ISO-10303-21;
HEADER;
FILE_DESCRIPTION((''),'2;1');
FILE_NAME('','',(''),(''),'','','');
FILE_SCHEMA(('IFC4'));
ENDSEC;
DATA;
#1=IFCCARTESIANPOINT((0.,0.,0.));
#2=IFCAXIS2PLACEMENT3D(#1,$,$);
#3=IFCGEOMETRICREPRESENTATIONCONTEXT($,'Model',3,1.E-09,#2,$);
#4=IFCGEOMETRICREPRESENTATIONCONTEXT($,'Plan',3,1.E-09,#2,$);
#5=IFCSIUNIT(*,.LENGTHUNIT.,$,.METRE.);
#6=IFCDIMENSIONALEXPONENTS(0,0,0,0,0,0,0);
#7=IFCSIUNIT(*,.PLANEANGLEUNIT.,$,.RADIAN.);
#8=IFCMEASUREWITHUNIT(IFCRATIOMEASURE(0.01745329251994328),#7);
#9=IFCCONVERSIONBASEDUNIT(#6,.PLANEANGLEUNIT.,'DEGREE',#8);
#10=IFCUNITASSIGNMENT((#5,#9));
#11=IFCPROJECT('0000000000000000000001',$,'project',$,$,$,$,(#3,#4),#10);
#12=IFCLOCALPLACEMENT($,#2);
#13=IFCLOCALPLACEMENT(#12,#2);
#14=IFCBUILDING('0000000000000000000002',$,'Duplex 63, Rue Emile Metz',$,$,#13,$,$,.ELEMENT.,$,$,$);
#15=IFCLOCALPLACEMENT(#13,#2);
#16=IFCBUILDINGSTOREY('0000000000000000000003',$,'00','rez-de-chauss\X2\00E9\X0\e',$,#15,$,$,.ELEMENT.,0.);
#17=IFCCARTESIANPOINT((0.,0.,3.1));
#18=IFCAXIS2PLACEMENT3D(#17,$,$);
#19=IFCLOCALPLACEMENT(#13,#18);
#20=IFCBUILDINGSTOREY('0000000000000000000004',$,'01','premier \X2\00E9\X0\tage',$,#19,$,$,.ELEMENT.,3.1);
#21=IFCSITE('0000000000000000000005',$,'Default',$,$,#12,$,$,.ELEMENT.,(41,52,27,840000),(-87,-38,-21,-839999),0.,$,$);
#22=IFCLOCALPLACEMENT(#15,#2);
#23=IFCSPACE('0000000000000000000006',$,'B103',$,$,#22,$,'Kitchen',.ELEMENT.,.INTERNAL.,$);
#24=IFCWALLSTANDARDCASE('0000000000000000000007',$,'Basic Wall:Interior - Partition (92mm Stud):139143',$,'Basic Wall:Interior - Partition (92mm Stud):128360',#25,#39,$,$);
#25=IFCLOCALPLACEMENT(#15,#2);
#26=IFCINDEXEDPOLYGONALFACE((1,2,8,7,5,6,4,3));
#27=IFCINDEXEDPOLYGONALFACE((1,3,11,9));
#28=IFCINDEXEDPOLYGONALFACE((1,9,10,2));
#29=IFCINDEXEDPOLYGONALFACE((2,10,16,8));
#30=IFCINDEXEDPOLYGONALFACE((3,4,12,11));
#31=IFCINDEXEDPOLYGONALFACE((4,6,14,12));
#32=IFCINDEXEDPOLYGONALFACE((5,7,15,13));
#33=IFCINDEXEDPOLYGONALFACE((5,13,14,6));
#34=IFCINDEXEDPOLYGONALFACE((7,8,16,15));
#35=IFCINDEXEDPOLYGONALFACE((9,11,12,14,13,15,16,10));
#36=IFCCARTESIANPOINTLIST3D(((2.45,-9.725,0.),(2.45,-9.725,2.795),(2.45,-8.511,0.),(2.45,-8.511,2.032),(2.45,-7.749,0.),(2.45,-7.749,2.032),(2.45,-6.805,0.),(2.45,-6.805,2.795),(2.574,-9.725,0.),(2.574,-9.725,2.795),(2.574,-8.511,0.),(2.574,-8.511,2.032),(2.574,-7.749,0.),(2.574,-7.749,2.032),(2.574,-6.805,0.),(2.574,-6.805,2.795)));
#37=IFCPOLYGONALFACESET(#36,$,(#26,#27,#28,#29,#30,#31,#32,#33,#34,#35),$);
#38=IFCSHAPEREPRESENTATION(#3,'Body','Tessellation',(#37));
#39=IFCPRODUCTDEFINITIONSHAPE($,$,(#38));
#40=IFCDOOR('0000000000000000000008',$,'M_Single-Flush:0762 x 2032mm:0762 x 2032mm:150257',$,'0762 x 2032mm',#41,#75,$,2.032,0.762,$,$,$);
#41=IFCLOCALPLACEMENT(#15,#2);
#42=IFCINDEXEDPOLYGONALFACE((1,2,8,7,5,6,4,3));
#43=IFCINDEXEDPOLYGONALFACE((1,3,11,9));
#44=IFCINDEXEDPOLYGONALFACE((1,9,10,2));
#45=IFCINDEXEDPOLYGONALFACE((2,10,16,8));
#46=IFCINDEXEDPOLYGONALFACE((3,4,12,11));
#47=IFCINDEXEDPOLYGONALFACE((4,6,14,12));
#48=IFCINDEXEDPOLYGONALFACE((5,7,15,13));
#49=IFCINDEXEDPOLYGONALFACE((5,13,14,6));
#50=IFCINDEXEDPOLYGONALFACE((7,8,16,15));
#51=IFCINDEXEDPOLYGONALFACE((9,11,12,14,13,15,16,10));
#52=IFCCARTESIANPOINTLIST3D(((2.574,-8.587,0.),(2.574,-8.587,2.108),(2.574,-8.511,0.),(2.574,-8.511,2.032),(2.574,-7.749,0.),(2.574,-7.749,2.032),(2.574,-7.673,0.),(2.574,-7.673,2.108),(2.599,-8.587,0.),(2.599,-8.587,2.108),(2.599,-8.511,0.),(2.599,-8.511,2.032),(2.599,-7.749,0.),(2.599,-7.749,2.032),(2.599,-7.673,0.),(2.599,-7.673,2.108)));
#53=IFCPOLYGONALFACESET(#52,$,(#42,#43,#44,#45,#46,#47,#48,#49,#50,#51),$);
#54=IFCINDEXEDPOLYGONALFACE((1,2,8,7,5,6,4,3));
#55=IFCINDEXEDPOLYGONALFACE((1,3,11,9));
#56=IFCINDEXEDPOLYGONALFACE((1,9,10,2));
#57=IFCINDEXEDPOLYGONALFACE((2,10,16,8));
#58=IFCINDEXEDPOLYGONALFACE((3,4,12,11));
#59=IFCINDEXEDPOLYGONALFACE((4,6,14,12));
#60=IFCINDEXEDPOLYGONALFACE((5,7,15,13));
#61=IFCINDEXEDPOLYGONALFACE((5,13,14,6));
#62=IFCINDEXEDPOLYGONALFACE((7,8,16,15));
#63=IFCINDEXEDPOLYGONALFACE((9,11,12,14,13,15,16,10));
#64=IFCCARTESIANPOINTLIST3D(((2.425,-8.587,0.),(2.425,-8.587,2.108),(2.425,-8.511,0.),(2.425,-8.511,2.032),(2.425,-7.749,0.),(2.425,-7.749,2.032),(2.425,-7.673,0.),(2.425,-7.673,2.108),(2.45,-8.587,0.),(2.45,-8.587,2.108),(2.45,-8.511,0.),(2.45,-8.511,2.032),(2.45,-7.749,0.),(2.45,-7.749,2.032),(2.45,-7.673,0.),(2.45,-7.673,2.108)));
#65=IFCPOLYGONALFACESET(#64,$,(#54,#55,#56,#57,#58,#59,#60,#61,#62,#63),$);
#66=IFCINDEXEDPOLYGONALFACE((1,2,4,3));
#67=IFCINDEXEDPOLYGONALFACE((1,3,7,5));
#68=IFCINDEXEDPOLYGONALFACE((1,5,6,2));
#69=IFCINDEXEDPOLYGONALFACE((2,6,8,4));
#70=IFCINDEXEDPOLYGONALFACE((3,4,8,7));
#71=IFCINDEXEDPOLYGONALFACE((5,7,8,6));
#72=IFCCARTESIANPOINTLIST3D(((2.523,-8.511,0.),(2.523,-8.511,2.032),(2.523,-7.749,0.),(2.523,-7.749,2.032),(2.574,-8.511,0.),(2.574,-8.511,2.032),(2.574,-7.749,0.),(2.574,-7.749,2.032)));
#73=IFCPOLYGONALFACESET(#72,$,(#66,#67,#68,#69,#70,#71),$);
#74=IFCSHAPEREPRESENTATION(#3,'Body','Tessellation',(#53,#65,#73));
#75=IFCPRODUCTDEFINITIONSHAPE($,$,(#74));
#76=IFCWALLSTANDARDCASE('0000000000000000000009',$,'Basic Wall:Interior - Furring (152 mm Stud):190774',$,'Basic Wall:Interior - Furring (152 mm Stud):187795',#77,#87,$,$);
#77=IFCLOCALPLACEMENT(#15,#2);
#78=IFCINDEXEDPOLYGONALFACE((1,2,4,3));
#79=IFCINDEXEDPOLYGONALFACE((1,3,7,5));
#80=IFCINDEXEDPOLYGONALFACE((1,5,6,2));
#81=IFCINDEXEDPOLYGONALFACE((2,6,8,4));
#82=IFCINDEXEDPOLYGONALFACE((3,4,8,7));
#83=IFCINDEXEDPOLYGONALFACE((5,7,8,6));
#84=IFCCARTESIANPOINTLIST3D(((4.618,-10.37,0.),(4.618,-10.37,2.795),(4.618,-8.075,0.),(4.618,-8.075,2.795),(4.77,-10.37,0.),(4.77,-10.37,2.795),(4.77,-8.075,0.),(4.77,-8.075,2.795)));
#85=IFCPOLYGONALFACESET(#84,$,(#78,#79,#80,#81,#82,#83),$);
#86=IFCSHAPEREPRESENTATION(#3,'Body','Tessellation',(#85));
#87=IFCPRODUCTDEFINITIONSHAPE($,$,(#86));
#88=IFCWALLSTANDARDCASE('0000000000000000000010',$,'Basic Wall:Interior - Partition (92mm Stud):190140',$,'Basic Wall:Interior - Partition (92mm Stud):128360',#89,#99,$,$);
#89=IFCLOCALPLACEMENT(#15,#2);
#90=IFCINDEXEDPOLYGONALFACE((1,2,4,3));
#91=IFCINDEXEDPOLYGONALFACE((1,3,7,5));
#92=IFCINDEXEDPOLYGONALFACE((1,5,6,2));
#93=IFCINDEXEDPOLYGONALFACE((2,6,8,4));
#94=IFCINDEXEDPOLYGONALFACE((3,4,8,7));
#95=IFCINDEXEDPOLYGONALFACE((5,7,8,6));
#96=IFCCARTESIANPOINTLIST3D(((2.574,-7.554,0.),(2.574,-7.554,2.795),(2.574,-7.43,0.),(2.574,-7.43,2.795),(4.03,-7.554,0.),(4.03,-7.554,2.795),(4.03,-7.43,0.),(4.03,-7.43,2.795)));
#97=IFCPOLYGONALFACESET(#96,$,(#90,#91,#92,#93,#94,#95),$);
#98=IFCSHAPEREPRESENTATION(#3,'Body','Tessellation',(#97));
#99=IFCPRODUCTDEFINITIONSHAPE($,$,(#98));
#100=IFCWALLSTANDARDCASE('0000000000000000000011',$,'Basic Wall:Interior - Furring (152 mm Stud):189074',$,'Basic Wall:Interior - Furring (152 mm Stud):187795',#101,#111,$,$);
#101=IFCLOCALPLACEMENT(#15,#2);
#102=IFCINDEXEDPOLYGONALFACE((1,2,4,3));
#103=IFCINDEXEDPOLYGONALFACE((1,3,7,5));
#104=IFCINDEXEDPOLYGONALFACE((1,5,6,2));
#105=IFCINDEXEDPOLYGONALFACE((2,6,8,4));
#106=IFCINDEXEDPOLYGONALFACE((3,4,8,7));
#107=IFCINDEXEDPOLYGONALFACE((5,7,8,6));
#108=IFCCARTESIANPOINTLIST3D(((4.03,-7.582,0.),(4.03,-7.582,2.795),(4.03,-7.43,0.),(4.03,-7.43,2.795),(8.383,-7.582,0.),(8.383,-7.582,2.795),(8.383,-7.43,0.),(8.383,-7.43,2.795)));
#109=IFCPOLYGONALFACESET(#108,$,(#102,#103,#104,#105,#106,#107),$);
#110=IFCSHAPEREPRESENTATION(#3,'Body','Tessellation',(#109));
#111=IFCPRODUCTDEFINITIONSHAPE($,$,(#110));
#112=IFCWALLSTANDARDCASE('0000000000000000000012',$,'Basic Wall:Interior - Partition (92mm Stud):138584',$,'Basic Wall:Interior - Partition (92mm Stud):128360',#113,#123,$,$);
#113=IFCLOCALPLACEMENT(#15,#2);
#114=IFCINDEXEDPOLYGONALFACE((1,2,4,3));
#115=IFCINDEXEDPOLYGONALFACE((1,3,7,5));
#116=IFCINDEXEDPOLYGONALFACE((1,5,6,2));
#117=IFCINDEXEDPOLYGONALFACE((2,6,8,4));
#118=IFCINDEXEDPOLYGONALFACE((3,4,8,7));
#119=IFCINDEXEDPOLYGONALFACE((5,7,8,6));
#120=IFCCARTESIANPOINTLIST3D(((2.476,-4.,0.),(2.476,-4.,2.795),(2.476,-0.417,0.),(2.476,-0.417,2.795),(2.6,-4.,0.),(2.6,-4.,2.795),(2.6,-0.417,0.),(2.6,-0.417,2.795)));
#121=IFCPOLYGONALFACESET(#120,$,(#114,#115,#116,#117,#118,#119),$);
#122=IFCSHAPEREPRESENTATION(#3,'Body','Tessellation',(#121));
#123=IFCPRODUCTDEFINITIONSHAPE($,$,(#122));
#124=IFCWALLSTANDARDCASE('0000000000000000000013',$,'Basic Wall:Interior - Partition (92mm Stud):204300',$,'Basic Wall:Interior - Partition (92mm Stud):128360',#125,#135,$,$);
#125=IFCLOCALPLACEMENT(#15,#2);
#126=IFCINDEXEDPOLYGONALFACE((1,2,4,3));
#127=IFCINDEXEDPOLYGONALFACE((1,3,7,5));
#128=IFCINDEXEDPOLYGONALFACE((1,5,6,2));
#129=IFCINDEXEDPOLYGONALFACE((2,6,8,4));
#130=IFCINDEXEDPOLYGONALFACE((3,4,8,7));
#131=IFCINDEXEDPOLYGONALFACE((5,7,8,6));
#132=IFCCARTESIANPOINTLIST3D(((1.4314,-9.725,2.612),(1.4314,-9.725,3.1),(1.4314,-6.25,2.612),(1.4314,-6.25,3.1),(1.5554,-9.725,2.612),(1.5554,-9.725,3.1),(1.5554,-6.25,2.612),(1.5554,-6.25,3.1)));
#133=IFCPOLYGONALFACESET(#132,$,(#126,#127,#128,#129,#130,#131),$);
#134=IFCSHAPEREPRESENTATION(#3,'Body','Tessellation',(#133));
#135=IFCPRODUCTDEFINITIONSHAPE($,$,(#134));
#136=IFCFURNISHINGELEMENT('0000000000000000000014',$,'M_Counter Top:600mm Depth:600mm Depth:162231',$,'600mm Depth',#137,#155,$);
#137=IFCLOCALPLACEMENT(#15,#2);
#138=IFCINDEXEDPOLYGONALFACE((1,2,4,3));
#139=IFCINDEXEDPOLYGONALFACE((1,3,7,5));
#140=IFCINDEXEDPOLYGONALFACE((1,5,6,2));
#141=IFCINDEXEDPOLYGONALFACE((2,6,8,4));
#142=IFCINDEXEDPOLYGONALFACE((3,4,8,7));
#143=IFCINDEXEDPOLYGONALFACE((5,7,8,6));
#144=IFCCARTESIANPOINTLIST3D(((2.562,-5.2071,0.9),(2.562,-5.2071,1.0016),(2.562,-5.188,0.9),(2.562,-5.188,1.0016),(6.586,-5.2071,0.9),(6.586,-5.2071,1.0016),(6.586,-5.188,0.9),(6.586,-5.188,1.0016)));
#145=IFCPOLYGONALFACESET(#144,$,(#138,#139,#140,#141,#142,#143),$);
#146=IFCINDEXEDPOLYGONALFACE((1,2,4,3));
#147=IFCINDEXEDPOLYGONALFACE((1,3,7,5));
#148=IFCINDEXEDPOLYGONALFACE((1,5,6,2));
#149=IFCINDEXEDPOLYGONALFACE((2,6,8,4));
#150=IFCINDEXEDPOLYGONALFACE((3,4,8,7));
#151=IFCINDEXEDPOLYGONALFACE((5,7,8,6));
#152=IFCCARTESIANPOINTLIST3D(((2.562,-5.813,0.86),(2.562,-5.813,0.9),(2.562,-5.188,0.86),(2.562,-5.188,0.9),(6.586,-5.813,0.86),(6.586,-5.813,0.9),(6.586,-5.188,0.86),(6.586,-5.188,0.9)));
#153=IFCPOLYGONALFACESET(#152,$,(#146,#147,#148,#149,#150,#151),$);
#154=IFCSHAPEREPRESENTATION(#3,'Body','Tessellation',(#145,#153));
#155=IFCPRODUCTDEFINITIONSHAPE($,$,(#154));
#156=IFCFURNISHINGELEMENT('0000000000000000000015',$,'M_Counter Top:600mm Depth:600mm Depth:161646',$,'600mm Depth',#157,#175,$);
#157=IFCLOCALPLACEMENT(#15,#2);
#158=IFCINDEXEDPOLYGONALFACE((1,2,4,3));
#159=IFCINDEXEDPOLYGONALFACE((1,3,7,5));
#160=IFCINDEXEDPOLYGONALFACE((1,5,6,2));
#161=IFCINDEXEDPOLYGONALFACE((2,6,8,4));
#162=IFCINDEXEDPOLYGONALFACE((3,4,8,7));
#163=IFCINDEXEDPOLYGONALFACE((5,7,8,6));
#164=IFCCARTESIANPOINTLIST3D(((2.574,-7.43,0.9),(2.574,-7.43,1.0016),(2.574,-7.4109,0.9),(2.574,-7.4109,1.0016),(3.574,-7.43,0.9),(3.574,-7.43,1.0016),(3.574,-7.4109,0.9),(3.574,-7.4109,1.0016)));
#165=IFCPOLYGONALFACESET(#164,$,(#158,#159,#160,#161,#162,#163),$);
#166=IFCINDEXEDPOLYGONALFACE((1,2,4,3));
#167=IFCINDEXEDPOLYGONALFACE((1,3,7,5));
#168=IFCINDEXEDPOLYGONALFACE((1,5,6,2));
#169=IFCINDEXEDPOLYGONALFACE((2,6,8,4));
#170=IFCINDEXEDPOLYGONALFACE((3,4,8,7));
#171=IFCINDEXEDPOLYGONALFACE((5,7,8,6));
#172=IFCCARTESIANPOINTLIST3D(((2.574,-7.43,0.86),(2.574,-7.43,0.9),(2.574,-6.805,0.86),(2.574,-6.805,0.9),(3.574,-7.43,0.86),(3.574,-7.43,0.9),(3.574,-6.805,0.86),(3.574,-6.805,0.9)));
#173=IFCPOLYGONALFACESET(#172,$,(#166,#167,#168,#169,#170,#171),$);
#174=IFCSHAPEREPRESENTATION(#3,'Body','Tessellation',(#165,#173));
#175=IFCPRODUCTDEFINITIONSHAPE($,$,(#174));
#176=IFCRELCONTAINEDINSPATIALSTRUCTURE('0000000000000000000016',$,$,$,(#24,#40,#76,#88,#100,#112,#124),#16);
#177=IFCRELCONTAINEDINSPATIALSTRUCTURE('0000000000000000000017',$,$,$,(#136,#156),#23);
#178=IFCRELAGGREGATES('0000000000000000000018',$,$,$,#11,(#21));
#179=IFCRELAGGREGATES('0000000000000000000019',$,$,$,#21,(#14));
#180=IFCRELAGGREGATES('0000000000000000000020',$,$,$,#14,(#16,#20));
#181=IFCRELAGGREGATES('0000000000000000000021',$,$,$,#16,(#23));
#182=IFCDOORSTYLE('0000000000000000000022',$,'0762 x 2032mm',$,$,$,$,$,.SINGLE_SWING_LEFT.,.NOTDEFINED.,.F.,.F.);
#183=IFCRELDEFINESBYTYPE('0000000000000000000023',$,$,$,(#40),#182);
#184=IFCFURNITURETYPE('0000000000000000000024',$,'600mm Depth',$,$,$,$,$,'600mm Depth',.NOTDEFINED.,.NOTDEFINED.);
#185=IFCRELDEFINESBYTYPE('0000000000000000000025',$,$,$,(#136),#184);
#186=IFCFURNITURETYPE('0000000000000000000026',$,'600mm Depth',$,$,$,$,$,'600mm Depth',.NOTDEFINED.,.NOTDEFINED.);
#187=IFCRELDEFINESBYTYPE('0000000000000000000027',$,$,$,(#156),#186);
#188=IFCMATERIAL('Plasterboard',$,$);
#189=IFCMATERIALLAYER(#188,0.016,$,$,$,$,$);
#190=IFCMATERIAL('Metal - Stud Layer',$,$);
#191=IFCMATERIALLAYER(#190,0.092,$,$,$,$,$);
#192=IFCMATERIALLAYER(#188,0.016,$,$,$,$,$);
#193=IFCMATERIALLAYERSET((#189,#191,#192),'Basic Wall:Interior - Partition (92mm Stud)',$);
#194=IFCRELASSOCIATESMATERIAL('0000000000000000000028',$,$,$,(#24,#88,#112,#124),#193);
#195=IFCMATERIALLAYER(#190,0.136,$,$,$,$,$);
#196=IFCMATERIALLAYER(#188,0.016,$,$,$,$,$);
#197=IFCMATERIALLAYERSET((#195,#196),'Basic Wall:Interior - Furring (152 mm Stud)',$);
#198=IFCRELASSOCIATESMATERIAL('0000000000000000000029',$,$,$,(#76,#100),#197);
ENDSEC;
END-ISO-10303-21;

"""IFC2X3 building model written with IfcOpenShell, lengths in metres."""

from ifc_helpers import new_model, entity, si_unit, converted_unit, frame, frame_2d, origin, origin_2d_with_axis, place, context, project, spatial, polyline, rectangle, outline, extrude, clip, bounded_halfspace, source, transform, mapped, material, layer, layer_set, layer_usage, type_object, type_shapes, element, fill, save


model = new_model("IFC2X3")

# Units and contexts
model_context = context("Model", 3, precision=1e-09, world=origin())
plan_context = context("Plan", 3, precision=1e-09, world=origin())
ifc_project = project(units=[si_unit("LENGTHUNIT", "METRE"), converted_unit("PLANEANGLEUNIT", "DEGREE", entity("IfcRatioMeasure", 0.01745329251994328), si_unit("PLANEANGLEUNIT", "RADIAN"), dimensions=[0, 0, 0, 0, 0, 0, 0])], contexts=[model_context, plan_context])

# Site, building, storey
site_placement = place(None, origin())
site = spatial("IfcSite", under=ifc_project, at=site_placement, Name="Default", CompositionType="ELEMENT", RefLatitude=(41, 52, 27, 840000), RefLongitude=(-87, -38, -21, -839999), RefElevation=0.0)
building_placement = place(site_placement, origin())
building = spatial("IfcBuilding", under=site, at=building_placement, Name="Duplex 63, Rue Emile Metz", CompositionType="ELEMENT")
storey_1_placement = place(building_placement, origin())
storey_1 = spatial("IfcBuildingStorey", under=building, at=storey_1_placement, Name="00", Description="rez-de-chaussée", CompositionType="ELEMENT", Elevation=0.0)

# Shared definitions
ifc_material_1 = material(Name="Metal - Stud Layer")
ifc_material_2 = material(Name="Plasterboard")

# Shared definitions
ifc_layer_1 = layer(ifc_material_2, 0.016)
ifc_layer_2 = layer(ifc_material_1, 0.092)
ifc_layer_3 = layer(ifc_material_2, 0.016)
ifc_layer_set_1 = layer_set([ifc_layer_1, ifc_layer_2, ifc_layer_3], Name="Basic Wall:Interior - Partition (92mm Stud)")
ifc_layer_usage_1 = layer_usage(ifc_layer_set_1, "AXIS2", "NEGATIVE", 0.062)

# Shared definitions
storey_2_placement = place(building_placement, frame((0.0, 0.0, 3.1)))
storey_2 = spatial("IfcBuildingStorey", under=building, at=storey_2_placement, Name="01", Description="premier étage", CompositionType="ELEMENT", Elevation=3.1)

# Wall, opening, door
wall_1_placement = place(storey_1_placement, frame((2.512, -6.805, 0.0), z_axis=(0.0, 0.0, 1.0), x_axis=(0.0, -1.0, 0.0)))
wall_1 = element("IfcWallStandardCase", 1, at=wall_1_placement, inside=storey_1, material=ifc_layer_usage_1, Name="Basic Wall:Interior - Partition (92mm Stud):139143", ObjectType="Basic Wall:Interior - Partition (92mm Stud):128360", context=model_context, shape_type="SweptSolid", body=[
    extrude(rectangle(XDim=2.92, YDim=0.124, at=frame_2d((1.46, 0.0), x_axis=(-1.0, 0.0))), origin(), (0.0, 0.0, 1.0), 2.795),
])
opening_1_placement = place(wall_1_placement, frame((0.944, -0.062, 0.0)))
opening_1 = element("IfcOpeningElement", 2, at=opening_1_placement, cuts=wall_1, ObjectType="Opening", context=model_context, shape_type="SweptSolid", body=[
    extrude(rectangle(XDim=0.762, YDim=2.032, at=frame_2d((1.016, 0.381), x_axis=(0.0, -1.0))), frame((0.0, 0.0, 0.0), z_axis=(0.0, 1.0, 0.0), x_axis=(0.0, 0.0, 1.0)), (0.0, 0.0, 1.0), 0.124),
])
door_style_1 = type_object("IfcDoorStyle", Name="0762 x 2032mm", ConstructionType="NOTDEFINED", OperationType="SINGLE_SWING_LEFT", ParameterTakesPrecedence=False, Sizeable=False)
shared_shape_1 = source(origin(), model_context, "Body", "SweptSolid", [
    extrude(outline(polyline([(-0.457, -1.073), (0.457, -1.073), (0.457, 1.035), (0.381, 1.035), (0.381, -0.997), (-0.381, -0.997), (-0.381, 1.035), (-0.457, 1.035), (-0.457, -1.073)])), frame((0.381, 0.149, 1.035), z_axis=(0.0, -1.0, 0.0), x_axis=(-1.0, 0.0, 0.0)), (0.0, 0.0, 1.0), 0.025),
    extrude(outline(polyline([(-1.073, -0.457), (1.035, -0.457), (1.035, -0.381), (-0.997, -0.381), (-0.997, 0.381), (1.035, 0.381), (1.035, 0.457), (-1.073, 0.457), (-1.073, -0.457)])), frame((0.381, 0.0, 1.035), z_axis=(0.0, -1.0, 0.0), x_axis=(0.0, 0.0, -1.0)), (0.0, 0.0, 1.0), 0.025),
    extrude(rectangle(XDim=0.762, YDim=0.051, at=origin_2d_with_axis()), frame((0.381, 0.0985, 0.0)), (0.0, 0.0, 1.0), 2.032),
])
type_shapes(door_style_1, [shared_shape_1])
door_1_placement = place(opening_1_placement, origin())
door_1 = element("IfcDoor", 3, at=door_1_placement, inside=storey_1, type_object=door_style_1, Name="M_Single-Flush:0762 x 2032mm:0762 x 2032mm:150257", ObjectType="0762 x 2032mm", OverallHeight=2.032, OverallWidth=0.762, context=model_context, shape_type="MappedRepresentation", body=[
    mapped(shared_shape_1, transform((0.0, 0.0, 0.0), scale=1.0)),
])
fill(opening_1, door_1)

# Walls
ifc_layer_4 = layer(ifc_material_1, 0.136)
ifc_layer_5 = layer(ifc_material_2, 0.016)
ifc_layer_set_2 = layer_set([ifc_layer_4, ifc_layer_5], Name="Basic Wall:Interior - Furring (152 mm Stud)")
ifc_layer_usage_2 = layer_usage(ifc_layer_set_2, "AXIS2", "POSITIVE", -0.076)
wall_2_placement = place(storey_1_placement, frame((4.694, -8.075, 0.0), z_axis=(0.0, 0.0, 1.0), x_axis=(0.0, -1.0, 0.0)))
element("IfcWallStandardCase", 4, at=wall_2_placement, inside=storey_1, material=ifc_layer_usage_2, Name="Basic Wall:Interior - Furring (152 mm Stud):190774", ObjectType="Basic Wall:Interior - Furring (152 mm Stud):187795", context=model_context, shape_type="SweptSolid", body=[
    extrude(rectangle(XDim=2.295, YDim=0.152, at=frame_2d((1.1475, 0.0), x_axis=(-1.0, 0.0))), origin(), (0.0, 0.0, 1.0), 2.795),
])
wall_3_placement = place(storey_1_placement, frame((4.03, -7.492, 0.0), z_axis=(0.0, 0.0, 1.0), x_axis=(-1.0, 0.0, 0.0)))
element("IfcWallStandardCase", 5, at=wall_3_placement, inside=storey_1, material=ifc_layer_usage_1, Name="Basic Wall:Interior - Partition (92mm Stud):190140", ObjectType="Basic Wall:Interior - Partition (92mm Stud):128360", context=model_context, shape_type="SweptSolid", body=[
    extrude(rectangle(XDim=1.456, YDim=0.124, at=frame_2d((0.728, 0.0), x_axis=(-1.0, 0.0))), origin(), (0.0, 0.0, 1.0), 2.795),
])
ifc_layer_usage_3 = layer_usage(ifc_layer_set_2, "AXIS2", "NEGATIVE", 0.076)
wall_4_placement = place(storey_1_placement, frame((8.383, -7.506, 0.0), z_axis=(0.0, 0.0, 1.0), x_axis=(-1.0, 0.0, 0.0)))
element("IfcWallStandardCase", 6, at=wall_4_placement, inside=storey_1, material=ifc_layer_usage_3, Name="Basic Wall:Interior - Furring (152 mm Stud):189074", ObjectType="Basic Wall:Interior - Furring (152 mm Stud):187795", context=model_context, shape_type="Clipping", body=[
    clip(extrude(rectangle(XDim=4.353, YDim=0.152, at=frame_2d((2.1765, 0.0), x_axis=(-1.0, 0.0))), origin(), (0.0, 0.0, 1.0), 2.795), bounded_halfspace(frame((0.0, -0.076, 2.795), z_axis=(0.0, 0.0, -1.0), x_axis=(0.0, 1.0, 0.0)), True, frame((0.0, -0.076, 2.795)), polyline([(0.0, 0.0), (3.708, 0.0), (3.708, 0.152), (0.0, 0.152), (0.0, 0.0)]))),
])
wall_5_placement = place(storey_1_placement, frame((2.538, -0.417, 0.0), z_axis=(0.0, 0.0, 1.0), x_axis=(0.0, -1.0, 0.0)))
element("IfcWallStandardCase", 7, at=wall_5_placement, inside=storey_1, material=ifc_layer_usage_1, Name="Basic Wall:Interior - Partition (92mm Stud):138584", ObjectType="Basic Wall:Interior - Partition (92mm Stud):128360", context=model_context, shape_type="SweptSolid", body=[
    extrude(rectangle(XDim=3.583, YDim=0.124, at=frame_2d((1.7915, 0.0), x_axis=(-1.0, 0.0))), origin(), (0.0, 0.0, 1.0), 2.795),
])
wall_6_placement = place(storey_1_placement, frame((1.4934, -6.25, 2.612), z_axis=(0.0, 0.0, 1.0), x_axis=(0.0, -1.0, 0.0)))
element("IfcWallStandardCase", 8, at=wall_6_placement, inside=storey_1, material=ifc_layer_usage_1, Name="Basic Wall:Interior - Partition (92mm Stud):204300", ObjectType="Basic Wall:Interior - Partition (92mm Stud):128360", context=model_context, shape_type="SweptSolid", body=[
    extrude(rectangle(XDim=3.475, YDim=0.124, at=frame_2d((1.7375, 0.0), x_axis=(-1.0, 0.0))), origin(), (0.0, 0.0, 1.0), 0.488),
])

# Shared definitions
space_1_placement = place(storey_1_placement, origin())
space_1 = spatial("IfcSpace", under=storey_1, at=space_1_placement, Name="B103", LongName="Kitchen", CompositionType="ELEMENT", InteriorOrExteriorSpace="INTERNAL")

# Furnishing elements
furniture_type_1 = type_object("IfcFurnitureType", Name="600mm Depth", ElementType="600mm Depth", AssemblyPlace="NOTDEFINED")
shared_shape_2 = source(origin(), model_context, "Body", "SweptSolid", [
    extrude(rectangle(XDim=0.0191, YDim=4.024, at=origin_2d_with_axis()), frame((0.8115, -0.0095, 0.9), z_axis=(0.0, 0.0, 1.0), x_axis=(0.0, -1.0, 0.0)), (0.0, 0.0, 1.0), 0.1016),
    extrude(rectangle(XDim=4.024, YDim=0.625, at=origin_2d_with_axis()), frame((0.8115, -0.3125, 0.86), z_axis=(0.0, 0.0, 1.0), x_axis=(-1.0, 0.0, 0.0)), (0.0, 0.0, 1.0), 0.04),
])
type_shapes(furniture_type_1, [shared_shape_2])
furnishing_1_placement = place(space_1_placement, frame((3.7625, -5.188, 0.0)))
element("IfcFurnishingElement", 9, at=furnishing_1_placement, inside=space_1, type_object=furniture_type_1, Name="M_Counter Top:600mm Depth:600mm Depth:162231", ObjectType="600mm Depth", context=model_context, shape_type="MappedRepresentation", body=[
    mapped(shared_shape_2, transform((0.0, 0.0, 0.0), scale=1.0)),
])
furniture_type_2 = type_object("IfcFurnitureType", Name="600mm Depth", ElementType="600mm Depth", AssemblyPlace="NOTDEFINED")
shared_shape_3 = source(origin(), model_context, "Body", "SweptSolid", [
    extrude(rectangle(XDim=0.0191, YDim=1.0, at=origin_2d_with_axis()), frame((-0.7005, -0.0095, 0.9), z_axis=(0.0, 0.0, 1.0), x_axis=(0.0, -1.0, 0.0)), (0.0, 0.0, 1.0), 0.1016),
    extrude(rectangle(XDim=1.0, YDim=0.625, at=origin_2d_with_axis()), frame((-0.7005, -0.3125, 0.86), z_axis=(0.0, 0.0, 1.0), x_axis=(-1.0, 0.0, 0.0)), (0.0, 0.0, 1.0), 0.04),
])
type_shapes(furniture_type_2, [shared_shape_3])
furnishing_2_placement = place(space_1_placement, frame((2.3735, -7.43, 0.0), z_axis=(0.0, 0.0, 1.0), x_axis=(-1.0, 0.0, 0.0)))
element("IfcFurnishingElement", 10, at=furnishing_2_placement, inside=space_1, type_object=furniture_type_2, Name="M_Counter Top:600mm Depth:600mm Depth:161646", ObjectType="600mm Depth", context=model_context, shape_type="MappedRepresentation", body=[
    mapped(shared_shape_3, transform((0.0, 0.0, 0.0), scale=1.0)),
])

save(model, "model.ifc")
